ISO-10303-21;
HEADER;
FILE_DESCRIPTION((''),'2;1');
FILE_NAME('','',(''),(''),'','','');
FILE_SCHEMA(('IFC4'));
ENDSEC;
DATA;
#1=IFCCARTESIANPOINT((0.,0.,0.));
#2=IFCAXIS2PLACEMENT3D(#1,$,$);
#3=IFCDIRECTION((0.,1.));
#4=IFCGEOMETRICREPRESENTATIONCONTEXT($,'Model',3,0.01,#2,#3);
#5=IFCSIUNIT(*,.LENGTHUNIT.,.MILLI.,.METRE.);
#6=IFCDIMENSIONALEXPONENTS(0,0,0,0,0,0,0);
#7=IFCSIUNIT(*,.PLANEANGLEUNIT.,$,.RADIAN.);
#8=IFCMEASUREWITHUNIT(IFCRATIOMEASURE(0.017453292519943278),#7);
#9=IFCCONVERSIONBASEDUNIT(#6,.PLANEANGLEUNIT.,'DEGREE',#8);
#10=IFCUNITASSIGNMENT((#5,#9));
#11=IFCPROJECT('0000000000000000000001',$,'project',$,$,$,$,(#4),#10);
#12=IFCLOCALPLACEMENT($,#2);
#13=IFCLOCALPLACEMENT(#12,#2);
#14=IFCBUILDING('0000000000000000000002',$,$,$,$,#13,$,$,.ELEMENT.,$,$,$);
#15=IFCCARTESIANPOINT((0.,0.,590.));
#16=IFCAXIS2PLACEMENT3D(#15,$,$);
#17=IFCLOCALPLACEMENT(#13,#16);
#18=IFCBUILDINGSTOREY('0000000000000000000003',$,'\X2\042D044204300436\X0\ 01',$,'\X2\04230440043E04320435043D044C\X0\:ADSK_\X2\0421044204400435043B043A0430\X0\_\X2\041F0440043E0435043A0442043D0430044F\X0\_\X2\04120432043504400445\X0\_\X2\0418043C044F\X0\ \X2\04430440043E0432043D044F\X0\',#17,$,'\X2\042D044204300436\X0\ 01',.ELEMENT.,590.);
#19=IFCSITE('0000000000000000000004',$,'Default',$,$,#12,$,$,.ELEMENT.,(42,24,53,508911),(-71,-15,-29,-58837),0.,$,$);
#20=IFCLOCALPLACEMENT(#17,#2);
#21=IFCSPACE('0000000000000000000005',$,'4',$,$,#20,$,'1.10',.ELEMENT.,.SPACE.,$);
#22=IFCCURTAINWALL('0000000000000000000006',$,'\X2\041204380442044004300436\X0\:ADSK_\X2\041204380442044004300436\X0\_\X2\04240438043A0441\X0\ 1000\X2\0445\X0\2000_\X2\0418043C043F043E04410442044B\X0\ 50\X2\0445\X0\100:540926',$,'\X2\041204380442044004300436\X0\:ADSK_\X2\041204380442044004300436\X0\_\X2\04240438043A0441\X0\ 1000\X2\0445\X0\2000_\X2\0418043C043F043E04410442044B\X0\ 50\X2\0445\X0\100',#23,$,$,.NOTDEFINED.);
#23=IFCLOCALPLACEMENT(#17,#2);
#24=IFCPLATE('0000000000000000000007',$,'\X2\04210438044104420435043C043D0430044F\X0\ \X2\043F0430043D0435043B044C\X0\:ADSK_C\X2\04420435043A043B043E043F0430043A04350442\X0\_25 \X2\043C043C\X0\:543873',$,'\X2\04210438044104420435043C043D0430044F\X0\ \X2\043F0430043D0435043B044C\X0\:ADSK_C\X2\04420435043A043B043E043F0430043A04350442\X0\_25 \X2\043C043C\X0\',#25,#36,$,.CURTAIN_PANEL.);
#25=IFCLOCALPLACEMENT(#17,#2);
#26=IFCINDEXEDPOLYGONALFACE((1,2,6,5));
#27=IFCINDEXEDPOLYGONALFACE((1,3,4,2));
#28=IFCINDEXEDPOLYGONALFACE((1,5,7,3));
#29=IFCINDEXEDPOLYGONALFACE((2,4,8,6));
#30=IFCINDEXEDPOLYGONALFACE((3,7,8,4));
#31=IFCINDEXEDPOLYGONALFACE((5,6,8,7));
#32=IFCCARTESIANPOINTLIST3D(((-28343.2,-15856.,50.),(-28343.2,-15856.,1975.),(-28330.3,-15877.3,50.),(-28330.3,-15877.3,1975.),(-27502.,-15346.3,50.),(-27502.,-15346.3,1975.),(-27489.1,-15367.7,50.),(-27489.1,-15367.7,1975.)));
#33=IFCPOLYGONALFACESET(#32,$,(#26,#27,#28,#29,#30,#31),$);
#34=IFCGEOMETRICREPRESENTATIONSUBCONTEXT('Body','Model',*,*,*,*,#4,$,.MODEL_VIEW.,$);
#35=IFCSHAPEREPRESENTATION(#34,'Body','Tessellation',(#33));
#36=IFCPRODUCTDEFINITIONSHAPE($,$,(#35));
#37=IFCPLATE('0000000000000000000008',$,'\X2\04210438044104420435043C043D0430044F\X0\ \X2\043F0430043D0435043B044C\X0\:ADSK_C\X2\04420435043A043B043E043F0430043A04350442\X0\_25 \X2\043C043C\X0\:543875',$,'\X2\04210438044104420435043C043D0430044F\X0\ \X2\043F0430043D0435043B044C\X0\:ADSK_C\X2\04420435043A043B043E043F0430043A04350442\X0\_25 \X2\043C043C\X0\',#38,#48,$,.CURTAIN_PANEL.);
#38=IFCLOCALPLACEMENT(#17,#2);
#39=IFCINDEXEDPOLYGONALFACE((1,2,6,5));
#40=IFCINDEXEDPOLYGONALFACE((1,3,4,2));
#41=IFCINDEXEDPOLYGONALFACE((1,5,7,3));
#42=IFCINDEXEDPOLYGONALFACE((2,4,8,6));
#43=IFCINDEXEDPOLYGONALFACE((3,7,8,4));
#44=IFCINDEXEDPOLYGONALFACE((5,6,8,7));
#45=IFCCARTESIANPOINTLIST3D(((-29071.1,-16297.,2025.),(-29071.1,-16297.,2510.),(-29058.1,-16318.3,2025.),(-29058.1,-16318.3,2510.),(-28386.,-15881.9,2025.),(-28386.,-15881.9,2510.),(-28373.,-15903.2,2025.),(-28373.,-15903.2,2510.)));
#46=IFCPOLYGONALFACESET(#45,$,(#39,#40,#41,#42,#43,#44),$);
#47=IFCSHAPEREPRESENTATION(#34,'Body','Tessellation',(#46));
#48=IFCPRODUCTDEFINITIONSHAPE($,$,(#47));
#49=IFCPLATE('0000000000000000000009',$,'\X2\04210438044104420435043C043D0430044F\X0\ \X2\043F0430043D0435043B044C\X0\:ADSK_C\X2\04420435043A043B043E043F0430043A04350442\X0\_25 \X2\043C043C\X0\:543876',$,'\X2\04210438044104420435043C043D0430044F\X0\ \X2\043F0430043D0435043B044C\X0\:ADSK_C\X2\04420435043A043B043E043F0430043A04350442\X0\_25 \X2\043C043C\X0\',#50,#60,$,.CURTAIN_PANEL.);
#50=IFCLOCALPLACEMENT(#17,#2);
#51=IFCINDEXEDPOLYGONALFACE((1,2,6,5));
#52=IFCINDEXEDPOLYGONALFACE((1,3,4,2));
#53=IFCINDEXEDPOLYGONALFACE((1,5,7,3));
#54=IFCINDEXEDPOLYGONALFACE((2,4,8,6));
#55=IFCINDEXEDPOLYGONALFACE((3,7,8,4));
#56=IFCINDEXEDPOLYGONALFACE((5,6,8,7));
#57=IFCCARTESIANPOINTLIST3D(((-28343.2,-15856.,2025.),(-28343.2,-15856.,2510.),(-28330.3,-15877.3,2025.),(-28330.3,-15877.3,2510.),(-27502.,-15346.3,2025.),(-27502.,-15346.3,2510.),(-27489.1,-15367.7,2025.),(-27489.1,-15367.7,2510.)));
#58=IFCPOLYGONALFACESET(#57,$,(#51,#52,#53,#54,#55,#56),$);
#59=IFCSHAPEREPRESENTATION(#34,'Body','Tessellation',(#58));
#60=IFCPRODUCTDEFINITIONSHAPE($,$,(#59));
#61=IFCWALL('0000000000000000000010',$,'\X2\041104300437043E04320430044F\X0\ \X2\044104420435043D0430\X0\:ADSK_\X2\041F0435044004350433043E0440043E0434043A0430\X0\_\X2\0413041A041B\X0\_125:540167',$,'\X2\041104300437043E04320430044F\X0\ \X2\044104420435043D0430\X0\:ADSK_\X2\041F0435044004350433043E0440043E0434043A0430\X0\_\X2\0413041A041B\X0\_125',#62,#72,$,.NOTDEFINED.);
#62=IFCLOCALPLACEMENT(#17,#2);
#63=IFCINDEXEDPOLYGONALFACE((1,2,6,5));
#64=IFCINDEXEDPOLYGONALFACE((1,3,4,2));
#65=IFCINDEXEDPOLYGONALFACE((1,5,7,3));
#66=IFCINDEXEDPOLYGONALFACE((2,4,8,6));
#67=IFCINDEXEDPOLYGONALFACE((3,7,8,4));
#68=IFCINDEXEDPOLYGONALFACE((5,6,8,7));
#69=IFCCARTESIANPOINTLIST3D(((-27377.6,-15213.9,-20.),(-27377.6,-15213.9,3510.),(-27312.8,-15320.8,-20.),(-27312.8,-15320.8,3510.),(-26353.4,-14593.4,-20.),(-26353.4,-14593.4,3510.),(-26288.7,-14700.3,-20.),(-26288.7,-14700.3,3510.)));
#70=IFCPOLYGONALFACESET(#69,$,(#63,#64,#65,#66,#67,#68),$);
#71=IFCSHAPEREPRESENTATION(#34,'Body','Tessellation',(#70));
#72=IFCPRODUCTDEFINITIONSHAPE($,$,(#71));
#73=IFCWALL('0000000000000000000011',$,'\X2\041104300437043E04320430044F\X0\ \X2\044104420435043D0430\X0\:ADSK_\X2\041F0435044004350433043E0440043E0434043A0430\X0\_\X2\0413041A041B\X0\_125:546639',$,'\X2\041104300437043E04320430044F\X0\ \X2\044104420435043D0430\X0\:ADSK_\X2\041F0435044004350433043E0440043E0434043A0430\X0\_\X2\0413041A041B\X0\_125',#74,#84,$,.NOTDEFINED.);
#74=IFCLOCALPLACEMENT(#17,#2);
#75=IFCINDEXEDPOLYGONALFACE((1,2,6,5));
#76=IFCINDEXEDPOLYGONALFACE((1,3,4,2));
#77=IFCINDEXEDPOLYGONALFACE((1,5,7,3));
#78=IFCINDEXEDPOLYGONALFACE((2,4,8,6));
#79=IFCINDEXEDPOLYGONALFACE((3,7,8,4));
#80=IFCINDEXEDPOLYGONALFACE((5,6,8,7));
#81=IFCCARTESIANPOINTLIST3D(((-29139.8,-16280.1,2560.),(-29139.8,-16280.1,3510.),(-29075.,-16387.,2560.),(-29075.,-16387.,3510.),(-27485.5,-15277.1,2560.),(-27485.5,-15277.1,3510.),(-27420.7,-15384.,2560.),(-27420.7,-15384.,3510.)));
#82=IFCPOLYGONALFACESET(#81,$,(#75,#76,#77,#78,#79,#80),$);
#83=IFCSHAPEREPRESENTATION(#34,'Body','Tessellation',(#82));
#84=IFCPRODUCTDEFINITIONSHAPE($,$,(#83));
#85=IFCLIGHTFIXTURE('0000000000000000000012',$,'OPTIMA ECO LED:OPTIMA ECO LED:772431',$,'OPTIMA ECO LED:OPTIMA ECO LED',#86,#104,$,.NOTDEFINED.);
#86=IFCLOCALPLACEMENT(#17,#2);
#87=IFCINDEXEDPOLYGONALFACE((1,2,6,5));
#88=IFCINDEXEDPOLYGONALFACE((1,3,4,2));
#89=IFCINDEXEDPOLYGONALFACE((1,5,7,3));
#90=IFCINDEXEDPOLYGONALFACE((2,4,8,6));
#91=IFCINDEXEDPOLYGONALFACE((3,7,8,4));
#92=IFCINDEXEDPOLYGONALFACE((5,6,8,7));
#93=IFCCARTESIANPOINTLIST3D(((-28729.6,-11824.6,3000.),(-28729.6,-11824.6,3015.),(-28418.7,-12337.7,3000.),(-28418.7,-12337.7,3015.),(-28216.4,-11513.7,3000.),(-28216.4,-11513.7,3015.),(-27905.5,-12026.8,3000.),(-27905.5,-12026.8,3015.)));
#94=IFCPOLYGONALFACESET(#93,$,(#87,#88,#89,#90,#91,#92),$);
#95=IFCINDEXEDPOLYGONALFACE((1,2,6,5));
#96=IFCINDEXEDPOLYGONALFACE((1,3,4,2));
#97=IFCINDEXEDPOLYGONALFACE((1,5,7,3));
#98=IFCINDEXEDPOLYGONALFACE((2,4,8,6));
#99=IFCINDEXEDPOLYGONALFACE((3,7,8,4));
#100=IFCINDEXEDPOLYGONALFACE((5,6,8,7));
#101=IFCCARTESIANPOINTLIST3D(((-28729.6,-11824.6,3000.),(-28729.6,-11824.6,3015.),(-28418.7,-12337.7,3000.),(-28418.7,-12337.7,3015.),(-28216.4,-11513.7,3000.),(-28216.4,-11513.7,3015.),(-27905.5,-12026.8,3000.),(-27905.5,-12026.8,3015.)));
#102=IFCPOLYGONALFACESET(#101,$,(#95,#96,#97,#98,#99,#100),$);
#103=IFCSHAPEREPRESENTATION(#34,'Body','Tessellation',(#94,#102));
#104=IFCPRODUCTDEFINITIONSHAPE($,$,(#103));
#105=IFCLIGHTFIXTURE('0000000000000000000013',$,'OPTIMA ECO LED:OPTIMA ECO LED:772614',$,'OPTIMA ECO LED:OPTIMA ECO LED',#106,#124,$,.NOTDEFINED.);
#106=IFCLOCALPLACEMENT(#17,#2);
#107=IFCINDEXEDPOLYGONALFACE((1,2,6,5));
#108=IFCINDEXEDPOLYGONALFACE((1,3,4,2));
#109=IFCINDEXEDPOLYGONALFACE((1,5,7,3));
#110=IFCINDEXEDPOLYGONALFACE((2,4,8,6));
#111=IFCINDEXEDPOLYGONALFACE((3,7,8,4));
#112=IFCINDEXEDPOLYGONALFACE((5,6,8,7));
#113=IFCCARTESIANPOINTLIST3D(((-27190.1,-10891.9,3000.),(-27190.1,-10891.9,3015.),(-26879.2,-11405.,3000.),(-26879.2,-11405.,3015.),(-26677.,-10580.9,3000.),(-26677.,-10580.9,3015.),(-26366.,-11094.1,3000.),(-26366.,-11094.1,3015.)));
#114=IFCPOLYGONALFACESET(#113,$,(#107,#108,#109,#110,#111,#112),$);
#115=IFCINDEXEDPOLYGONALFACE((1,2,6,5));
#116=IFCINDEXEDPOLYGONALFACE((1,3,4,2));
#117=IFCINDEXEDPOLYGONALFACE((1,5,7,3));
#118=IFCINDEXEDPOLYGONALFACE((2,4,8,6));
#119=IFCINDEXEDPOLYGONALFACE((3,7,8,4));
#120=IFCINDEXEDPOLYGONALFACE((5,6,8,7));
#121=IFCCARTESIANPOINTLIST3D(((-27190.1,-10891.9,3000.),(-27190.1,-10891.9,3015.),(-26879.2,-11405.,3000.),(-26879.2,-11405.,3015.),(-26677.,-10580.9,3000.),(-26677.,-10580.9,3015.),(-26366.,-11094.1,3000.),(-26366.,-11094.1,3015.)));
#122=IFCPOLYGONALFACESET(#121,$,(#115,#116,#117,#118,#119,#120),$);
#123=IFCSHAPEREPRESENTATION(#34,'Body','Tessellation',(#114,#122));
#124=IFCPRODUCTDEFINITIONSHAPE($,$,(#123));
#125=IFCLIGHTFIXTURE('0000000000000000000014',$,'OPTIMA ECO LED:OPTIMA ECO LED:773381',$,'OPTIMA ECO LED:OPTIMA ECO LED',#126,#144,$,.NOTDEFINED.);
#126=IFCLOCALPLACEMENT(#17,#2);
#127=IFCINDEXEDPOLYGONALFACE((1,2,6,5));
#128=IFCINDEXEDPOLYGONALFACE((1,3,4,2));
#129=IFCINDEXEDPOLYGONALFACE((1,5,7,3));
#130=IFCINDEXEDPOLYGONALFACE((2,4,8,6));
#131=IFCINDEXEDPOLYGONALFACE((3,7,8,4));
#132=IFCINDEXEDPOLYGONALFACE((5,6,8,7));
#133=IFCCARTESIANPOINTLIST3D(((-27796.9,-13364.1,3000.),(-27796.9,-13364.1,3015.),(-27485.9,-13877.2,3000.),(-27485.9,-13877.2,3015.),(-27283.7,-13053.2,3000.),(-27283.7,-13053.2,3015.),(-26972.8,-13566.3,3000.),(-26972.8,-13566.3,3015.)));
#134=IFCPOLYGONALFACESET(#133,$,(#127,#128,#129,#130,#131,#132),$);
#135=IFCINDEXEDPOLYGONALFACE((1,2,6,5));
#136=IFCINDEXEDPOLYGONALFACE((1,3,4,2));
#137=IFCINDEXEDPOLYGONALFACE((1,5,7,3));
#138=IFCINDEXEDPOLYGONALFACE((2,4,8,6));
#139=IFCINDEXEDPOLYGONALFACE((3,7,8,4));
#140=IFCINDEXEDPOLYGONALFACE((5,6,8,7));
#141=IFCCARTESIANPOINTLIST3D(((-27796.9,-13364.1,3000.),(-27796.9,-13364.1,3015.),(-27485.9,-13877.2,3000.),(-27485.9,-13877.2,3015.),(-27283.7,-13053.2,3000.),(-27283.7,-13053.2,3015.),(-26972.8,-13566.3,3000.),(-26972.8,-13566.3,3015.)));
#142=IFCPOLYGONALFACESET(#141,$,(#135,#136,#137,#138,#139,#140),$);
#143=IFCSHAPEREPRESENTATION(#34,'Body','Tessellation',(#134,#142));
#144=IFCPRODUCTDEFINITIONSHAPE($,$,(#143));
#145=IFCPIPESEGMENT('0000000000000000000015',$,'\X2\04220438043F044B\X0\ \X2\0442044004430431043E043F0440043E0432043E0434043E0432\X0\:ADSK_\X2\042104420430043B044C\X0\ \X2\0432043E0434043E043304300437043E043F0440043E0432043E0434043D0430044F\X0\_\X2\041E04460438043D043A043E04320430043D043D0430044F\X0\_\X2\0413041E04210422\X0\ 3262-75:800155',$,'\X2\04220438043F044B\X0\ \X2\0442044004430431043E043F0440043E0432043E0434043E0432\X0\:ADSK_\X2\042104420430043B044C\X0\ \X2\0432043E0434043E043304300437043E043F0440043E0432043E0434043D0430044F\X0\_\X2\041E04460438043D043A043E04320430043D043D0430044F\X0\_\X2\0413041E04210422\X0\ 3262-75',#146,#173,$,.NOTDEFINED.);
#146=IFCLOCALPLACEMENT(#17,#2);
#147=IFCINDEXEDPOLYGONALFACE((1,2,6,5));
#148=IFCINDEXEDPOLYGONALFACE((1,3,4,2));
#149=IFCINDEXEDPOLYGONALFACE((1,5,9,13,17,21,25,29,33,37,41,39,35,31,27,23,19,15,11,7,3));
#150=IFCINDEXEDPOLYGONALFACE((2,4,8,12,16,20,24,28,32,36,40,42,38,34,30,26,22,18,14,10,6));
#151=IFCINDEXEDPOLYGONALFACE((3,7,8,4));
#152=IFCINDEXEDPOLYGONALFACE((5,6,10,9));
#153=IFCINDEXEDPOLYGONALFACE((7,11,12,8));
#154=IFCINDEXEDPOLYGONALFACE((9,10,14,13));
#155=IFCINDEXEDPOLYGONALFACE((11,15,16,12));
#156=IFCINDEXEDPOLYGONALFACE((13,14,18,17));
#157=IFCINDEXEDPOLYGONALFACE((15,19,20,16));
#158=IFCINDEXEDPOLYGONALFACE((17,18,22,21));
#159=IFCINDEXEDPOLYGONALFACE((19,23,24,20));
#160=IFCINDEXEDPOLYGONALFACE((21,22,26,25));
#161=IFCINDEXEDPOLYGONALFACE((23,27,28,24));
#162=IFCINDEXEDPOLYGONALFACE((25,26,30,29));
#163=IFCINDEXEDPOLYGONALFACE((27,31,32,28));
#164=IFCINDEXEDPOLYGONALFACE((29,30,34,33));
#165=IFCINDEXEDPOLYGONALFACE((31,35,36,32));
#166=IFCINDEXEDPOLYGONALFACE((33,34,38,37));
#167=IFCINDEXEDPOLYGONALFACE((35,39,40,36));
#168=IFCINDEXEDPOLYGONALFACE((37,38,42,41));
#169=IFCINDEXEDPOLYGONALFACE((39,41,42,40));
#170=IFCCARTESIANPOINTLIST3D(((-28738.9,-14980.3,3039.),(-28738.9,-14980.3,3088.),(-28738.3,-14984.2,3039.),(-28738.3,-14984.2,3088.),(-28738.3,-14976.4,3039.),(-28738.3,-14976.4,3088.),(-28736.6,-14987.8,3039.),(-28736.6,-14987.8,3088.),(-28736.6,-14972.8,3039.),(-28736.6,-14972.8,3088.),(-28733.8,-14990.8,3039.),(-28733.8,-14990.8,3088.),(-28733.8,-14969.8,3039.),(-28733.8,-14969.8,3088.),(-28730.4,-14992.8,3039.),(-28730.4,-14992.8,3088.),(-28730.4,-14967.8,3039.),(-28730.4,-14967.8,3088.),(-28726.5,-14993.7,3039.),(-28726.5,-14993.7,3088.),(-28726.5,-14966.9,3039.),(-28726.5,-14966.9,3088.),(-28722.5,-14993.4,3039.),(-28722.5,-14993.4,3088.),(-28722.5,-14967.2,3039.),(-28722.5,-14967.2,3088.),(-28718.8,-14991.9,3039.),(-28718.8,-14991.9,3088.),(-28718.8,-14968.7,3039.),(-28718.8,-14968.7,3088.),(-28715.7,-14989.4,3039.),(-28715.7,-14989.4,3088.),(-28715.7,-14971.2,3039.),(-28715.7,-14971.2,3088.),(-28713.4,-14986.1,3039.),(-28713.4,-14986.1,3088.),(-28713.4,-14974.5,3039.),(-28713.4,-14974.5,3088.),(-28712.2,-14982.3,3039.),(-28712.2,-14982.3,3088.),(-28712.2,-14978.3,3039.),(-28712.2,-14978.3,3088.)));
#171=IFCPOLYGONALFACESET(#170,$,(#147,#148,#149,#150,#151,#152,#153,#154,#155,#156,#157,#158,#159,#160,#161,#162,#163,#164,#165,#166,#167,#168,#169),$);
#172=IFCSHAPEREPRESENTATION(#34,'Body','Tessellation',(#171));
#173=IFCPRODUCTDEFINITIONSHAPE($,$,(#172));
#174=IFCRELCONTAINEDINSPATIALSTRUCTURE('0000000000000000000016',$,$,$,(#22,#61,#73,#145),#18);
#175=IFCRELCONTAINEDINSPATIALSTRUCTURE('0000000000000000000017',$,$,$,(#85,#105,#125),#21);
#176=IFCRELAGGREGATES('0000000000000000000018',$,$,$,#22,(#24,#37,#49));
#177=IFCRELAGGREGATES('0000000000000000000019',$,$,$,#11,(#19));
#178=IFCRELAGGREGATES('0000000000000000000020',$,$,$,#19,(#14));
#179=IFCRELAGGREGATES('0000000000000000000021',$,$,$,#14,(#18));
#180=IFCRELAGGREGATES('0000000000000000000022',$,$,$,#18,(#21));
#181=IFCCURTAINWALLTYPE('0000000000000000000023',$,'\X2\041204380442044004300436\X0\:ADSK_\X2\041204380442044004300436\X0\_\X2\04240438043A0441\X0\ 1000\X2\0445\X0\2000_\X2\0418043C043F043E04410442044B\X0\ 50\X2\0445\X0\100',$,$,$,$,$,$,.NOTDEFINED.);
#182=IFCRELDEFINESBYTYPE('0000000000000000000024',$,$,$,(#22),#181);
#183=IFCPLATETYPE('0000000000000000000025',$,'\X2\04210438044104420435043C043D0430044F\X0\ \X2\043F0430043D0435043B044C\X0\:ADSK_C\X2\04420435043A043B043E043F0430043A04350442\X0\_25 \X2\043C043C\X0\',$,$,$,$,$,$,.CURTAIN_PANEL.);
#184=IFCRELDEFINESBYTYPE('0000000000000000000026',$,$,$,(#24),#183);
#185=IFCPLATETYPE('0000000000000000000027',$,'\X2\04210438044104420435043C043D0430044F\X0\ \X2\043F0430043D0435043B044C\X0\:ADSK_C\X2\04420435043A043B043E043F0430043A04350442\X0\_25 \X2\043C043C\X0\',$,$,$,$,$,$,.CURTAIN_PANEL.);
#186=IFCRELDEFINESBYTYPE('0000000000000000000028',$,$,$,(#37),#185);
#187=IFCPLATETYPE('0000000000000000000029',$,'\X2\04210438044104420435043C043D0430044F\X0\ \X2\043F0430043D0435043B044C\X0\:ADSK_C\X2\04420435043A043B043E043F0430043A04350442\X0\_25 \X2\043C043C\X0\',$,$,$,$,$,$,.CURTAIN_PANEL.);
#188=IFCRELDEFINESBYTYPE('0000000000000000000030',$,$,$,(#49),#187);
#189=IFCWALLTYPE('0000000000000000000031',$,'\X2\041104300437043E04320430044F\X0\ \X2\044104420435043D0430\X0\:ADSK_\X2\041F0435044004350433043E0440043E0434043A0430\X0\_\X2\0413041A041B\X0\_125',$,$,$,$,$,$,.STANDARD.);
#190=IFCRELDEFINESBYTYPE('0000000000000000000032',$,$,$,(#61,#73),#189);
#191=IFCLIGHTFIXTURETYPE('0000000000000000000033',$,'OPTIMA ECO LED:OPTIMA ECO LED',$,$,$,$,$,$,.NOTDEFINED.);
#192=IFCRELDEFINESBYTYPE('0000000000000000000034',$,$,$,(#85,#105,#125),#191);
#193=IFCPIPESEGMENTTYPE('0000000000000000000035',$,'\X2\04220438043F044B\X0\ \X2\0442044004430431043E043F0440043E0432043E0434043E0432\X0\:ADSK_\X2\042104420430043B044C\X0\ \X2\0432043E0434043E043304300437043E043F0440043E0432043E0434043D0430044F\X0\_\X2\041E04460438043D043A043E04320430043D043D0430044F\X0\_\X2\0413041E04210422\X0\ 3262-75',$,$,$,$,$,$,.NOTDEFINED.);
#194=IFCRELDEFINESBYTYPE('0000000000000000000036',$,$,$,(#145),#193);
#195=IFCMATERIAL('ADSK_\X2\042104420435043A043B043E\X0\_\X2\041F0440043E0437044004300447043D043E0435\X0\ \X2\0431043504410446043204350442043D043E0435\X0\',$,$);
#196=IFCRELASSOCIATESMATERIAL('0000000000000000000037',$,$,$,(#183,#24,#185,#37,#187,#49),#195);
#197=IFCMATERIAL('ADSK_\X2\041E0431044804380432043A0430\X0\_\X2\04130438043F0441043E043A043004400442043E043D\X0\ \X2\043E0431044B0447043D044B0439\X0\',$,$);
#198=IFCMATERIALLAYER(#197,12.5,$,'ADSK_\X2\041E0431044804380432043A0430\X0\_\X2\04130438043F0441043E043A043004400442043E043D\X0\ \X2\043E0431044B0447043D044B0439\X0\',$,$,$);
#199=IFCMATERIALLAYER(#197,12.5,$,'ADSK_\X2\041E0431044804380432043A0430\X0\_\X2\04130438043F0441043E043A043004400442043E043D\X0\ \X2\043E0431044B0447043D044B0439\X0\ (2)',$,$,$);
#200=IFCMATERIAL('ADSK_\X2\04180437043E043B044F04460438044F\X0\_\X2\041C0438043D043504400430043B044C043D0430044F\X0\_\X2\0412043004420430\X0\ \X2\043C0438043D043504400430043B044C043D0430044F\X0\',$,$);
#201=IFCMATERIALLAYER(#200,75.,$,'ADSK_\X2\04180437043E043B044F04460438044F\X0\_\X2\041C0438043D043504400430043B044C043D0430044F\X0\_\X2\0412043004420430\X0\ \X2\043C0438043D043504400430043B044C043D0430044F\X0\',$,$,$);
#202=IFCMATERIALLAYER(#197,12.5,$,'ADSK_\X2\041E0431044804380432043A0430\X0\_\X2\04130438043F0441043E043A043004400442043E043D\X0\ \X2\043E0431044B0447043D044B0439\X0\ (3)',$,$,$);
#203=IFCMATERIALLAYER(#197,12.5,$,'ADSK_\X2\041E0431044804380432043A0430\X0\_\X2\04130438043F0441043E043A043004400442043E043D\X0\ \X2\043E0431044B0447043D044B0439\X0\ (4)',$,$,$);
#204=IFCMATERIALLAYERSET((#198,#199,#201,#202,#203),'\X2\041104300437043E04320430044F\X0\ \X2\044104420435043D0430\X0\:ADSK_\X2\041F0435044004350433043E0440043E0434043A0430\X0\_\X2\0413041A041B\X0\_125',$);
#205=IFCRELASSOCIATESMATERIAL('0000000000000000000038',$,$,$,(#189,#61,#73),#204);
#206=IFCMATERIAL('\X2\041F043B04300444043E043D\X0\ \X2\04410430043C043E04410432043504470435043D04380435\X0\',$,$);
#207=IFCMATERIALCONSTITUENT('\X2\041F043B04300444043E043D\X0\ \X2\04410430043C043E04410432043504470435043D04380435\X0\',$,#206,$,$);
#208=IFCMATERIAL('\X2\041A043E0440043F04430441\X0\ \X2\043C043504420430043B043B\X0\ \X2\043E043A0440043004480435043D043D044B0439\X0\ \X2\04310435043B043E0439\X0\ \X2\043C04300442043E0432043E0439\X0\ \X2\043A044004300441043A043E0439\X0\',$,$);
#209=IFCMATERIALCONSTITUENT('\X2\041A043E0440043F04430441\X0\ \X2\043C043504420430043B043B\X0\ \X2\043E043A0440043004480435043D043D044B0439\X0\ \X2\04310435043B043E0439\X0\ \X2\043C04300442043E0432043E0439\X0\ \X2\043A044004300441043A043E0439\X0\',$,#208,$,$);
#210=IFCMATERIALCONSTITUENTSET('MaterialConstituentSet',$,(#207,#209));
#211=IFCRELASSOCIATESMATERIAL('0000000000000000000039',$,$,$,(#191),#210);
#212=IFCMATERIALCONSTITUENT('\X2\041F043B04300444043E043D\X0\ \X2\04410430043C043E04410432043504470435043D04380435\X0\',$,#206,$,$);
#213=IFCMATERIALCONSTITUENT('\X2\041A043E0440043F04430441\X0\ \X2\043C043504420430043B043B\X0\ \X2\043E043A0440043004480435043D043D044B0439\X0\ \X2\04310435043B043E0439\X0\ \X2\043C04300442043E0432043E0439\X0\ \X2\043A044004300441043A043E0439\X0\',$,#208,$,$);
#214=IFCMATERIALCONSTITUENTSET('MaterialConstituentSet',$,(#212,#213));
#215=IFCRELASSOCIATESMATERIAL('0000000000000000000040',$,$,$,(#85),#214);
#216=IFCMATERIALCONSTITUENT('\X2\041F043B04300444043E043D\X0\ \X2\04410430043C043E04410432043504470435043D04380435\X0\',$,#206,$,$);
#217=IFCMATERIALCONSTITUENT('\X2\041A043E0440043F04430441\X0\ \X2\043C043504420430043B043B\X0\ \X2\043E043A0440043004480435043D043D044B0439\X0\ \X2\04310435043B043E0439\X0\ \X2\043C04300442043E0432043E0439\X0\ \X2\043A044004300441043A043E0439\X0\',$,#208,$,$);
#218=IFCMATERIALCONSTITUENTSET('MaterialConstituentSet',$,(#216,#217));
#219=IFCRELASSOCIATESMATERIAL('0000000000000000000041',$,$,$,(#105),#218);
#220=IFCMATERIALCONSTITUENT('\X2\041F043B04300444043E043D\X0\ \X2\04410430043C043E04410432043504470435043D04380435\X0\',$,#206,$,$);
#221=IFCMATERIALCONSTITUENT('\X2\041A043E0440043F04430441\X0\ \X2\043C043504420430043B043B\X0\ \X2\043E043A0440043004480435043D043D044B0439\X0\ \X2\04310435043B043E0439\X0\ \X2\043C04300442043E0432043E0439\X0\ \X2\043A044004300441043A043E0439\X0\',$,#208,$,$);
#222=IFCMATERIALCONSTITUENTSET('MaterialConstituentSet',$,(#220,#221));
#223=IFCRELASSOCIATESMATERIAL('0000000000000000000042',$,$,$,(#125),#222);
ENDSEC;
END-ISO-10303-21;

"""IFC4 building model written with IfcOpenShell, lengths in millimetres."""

from ifc_helpers import new_model, entity, si_unit, converted_unit, direction, frame, frame_2d, origin, origin_2d_with_axis, place, context, subcontext, project, spatial, polyline, rectangle, circle, outline, extrude, source, transform, mapped, material, layer, layer_set, layer_usage, constituent, constituent_set, type_object, type_shapes, element, aggregate, save


model = new_model("IFC4")

# Units and contexts
model_context = context("Model", 3, precision=0.01, world=origin(), true_north=direction((0.0, 1.0)))
body_context = subcontext(model_context, "Body", "Model", "MODEL_VIEW")
ifc_project = project(units=[si_unit("LENGTHUNIT", "METRE", prefix="MILLI"), converted_unit("PLANEANGLEUNIT", "DEGREE", entity("IfcRatioMeasure", 0.017453292519943278), si_unit("PLANEANGLEUNIT", "RADIAN"), dimensions=[0, 0, 0, 0, 0, 0, 0])], contexts=[model_context])

# Site, building, storey
site_placement = place(None, origin())
site = spatial("IfcSite", under=ifc_project, at=site_placement, Name="Default", CompositionType="ELEMENT", RefLatitude=(42, 24, 53, 508911), RefLongitude=(-71, -15, -29, -58837), RefElevation=0.0)
building_placement = place(site_placement, origin())
building = spatial("IfcBuilding", under=site, at=building_placement, CompositionType="ELEMENT")
storey_placement = place(building_placement, frame((0.0, 0.0, 590.0)))
storey = spatial("IfcBuildingStorey", under=building, at=storey_placement, Name="Этаж 01", ObjectType="Уровень:ADSK_Стрелка_Проектная_Вверх_Имя уровня", LongName="Этаж 01", CompositionType="ELEMENT", Elevation=590.0)

# Curtain wall
curtain_wall_type = type_object("IfcCurtainWallType", Name="Витраж:ADSK_Витраж_Фикс 1000х2000_Импосты 50х100", PredefinedType="NOTDEFINED")
curtain_wall_placement = place(storey_placement, frame((0.0, 0.0, -590.0)))
curtain_wall = element("IfcCurtainWall", 1, at=curtain_wall_placement, inside=storey, type_object=curtain_wall_type, Name="Витраж:ADSK_Витраж_Фикс 1000х2000_Импосты 50х100:540926", ObjectType="Витраж:ADSK_Витраж_Фикс 1000х2000_Импосты 50х100", PredefinedType="NOTDEFINED")

# Plates
ifc_material_1 = material(Name="ADSK_Стекло_Прозрачное бесцветное")
plate_type_1 = type_object("IfcPlateType", Name="Системная панель:ADSK_Cтеклопакет_25 мм", PredefinedType="CURTAIN_PANEL", material=ifc_material_1)
shared_shape_1 = source(origin(), body_context, "Body", "SweptSolid", [
    extrude(rectangle(XDim=25.0, YDim=983.5, at=frame_2d((0.0, 0.0), x_axis=(1.0, 0.0))), frame((0.0, 0.0, 0.0), z_axis=(0.0, 0.0, 1.0), x_axis=(0.0, 1.0, 0.0)), (0.0, 0.0, 1.0), 1925.0),
])
type_shapes(plate_type_1, [shared_shape_1])
plate_1_placement = place(curtain_wall_placement, frame((-27916.1, -15611.8, 640.0), z_axis=(0.0, 0.0, 1.0), x_axis=(0.855267, 0.518188, 0.0)))
plate_1 = element("IfcPlate", 2, at=plate_1_placement, type_object=plate_type_1, material=ifc_material_1, Name="Системная панель:ADSK_Cтеклопакет_25 мм:543873", ObjectType="Системная панель:ADSK_Cтеклопакет_25 мм", PredefinedType="CURTAIN_PANEL", context=body_context, shape_type="MappedRepresentation", body=[
    mapped(shared_shape_1, transform((0.0, 0.0, 0.0), scale=1.0)),
])
plate_type_2 = type_object("IfcPlateType", Name="Системная панель:ADSK_Cтеклопакет_25 мм", PredefinedType="CURTAIN_PANEL", material=ifc_material_1)
shared_shape_2 = source(origin(), body_context, "Body", "SweptSolid", [
    extrude(rectangle(XDim=25.0, YDim=801.0, at=frame_2d((0.0, 0.0), x_axis=(1.0, 0.0))), frame((0.0, 0.0, 0.0), z_axis=(0.0, 0.0, 1.0), x_axis=(0.0, 1.0, 0.0)), (0.0, 0.0, 1.0), 485.0),
])
type_shapes(plate_type_2, [shared_shape_2])
plate_2_placement = place(curtain_wall_placement, frame((-28722.0, -16100.1, 2615.0), z_axis=(0.0, 0.0, 1.0), x_axis=(0.855267, 0.518188, 0.0)))
plate_2 = element("IfcPlate", 3, at=plate_2_placement, type_object=plate_type_2, material=ifc_material_1, Name="Системная панель:ADSK_Cтеклопакет_25 мм:543875", ObjectType="Системная панель:ADSK_Cтеклопакет_25 мм", PredefinedType="CURTAIN_PANEL", context=body_context, shape_type="MappedRepresentation", body=[
    mapped(shared_shape_2, transform((0.0, 0.0, 0.0), scale=1.0)),
])
plate_type_3 = type_object("IfcPlateType", Name="Системная панель:ADSK_Cтеклопакет_25 мм", PredefinedType="CURTAIN_PANEL", material=ifc_material_1)
shared_shape_3 = source(origin(), body_context, "Body", "SweptSolid", [
    extrude(rectangle(XDim=25.0, YDim=983.5, at=frame_2d((0.0, 0.0), x_axis=(1.0, 0.0))), frame((0.0, 0.0, 0.0), z_axis=(0.0, 0.0, 1.0), x_axis=(0.0, 1.0, 0.0)), (0.0, 0.0, 1.0), 485.0),
])
type_shapes(plate_type_3, [shared_shape_3])
plate_3_placement = place(curtain_wall_placement, frame((-27916.1, -15611.8, 2615.0), z_axis=(0.0, 0.0, 1.0), x_axis=(0.855267, 0.518188, 0.0)))
plate_3 = element("IfcPlate", 4, at=plate_3_placement, type_object=plate_type_3, material=ifc_material_1, Name="Системная панель:ADSK_Cтеклопакет_25 мм:543876", ObjectType="Системная панель:ADSK_Cтеклопакет_25 мм", PredefinedType="CURTAIN_PANEL", context=body_context, shape_type="MappedRepresentation", body=[
    mapped(shared_shape_3, transform((0.0, 0.0, 0.0), scale=1.0)),
])
aggregate(curtain_wall, [plate_1, plate_2, plate_3])

# Walls
ifc_material_2 = material(Name="ADSK_Обшивка_Гипсокартон обычный")
ifc_layer_1 = layer(ifc_material_2, 12.5, Name="ADSK_Обшивка_Гипсокартон обычный")
ifc_layer_2 = layer(ifc_material_2, 12.5, Name="ADSK_Обшивка_Гипсокартон обычный (2)")
ifc_material_3 = material(Name="ADSK_Изоляция_Минеральная_Вата минеральная")
ifc_layer_3 = layer(ifc_material_3, 75.0, Name="ADSK_Изоляция_Минеральная_Вата минеральная")
ifc_layer_4 = layer(ifc_material_2, 12.5, Name="ADSK_Обшивка_Гипсокартон обычный (3)")
ifc_layer_5 = layer(ifc_material_2, 12.5, Name="ADSK_Обшивка_Гипсокартон обычный (4)")
ifc_layer_set = layer_set([ifc_layer_1, ifc_layer_2, ifc_layer_3, ifc_layer_4, ifc_layer_5], Name="Базовая стена:ADSK_Перегородка_ГКЛ_125")
ifc_layer_usage_1 = layer_usage(ifc_layer_set, "AXIS2", "NEGATIVE", 62.5)
wall_type = type_object("IfcWallType", Name="Базовая стена:ADSK_Перегородка_ГКЛ_125", PredefinedType="STANDARD", material=ifc_layer_set)
wall_1_placement = place(storey_placement, frame((-27345.2, -15267.4, -20.0), z_axis=(0.0, 0.0, 1.0), x_axis=(0.855267, 0.518188, 0.0)))
element("IfcWall", 5, at=wall_1_placement, inside=storey, type_object=wall_type, material=ifc_layer_usage_1, Name="Базовая стена:ADSK_Перегородка_ГКЛ_125:540167", ObjectType="Базовая стена:ADSK_Перегородка_ГКЛ_125", PredefinedType="NOTDEFINED", context=body_context, shape_type="SweptSolid", body=[
    extrude(rectangle(XDim=1197.5, YDim=125.0, at=frame_2d((598.7, 0.0), x_axis=(-1.0, 0.0))), origin(), (0.0, 0.0, 1.0), 3530.0),
])
ifc_layer_usage_2 = layer_usage(ifc_layer_set, "AXIS2", "NEGATIVE", 62.5)
wall_2_placement = place(storey_placement, frame((-29107.4, -16333.6, 2560.0), z_axis=(0.0, 0.0, 1.0), x_axis=(0.855102, 0.51846, 0.0)))
element("IfcWall", 6, at=wall_2_placement, inside=storey, type_object=wall_type, material=ifc_layer_usage_2, Name="Базовая стена:ADSK_Перегородка_ГКЛ_125:546639", ObjectType="Базовая стена:ADSK_Перегородка_ГКЛ_125", PredefinedType="NOTDEFINED", context=body_context, shape_type="SweptSolid", body=[
    extrude(outline(polyline([(1934.6, -62.5), (1934.6, 62.5), (0.0, 62.5), (0.0, -62.5), (1934.6, -62.5)])), origin(), (0.0, 0.0, 1.0), 950.0),
])

# Shared definitions
space_1_placement = place(storey_placement, origin())
space_1 = spatial("IfcSpace", under=storey, at=space_1_placement, Name="4", LongName="1.10", CompositionType="ELEMENT", PredefinedType="SPACE")

# Light fixtures
ifc_material_4 = material(Name="Плафон самосвечение")
ifc_constituent_1 = constituent(ifc_material_4, Name="Плафон самосвечение")
ifc_material_5 = material(Name="Корпус металл окрашенный белой матовой краской")
ifc_constituent_2 = constituent(ifc_material_5, Name="Корпус металл окрашенный белой матовой краской")
ifc_constituent_set_1 = constituent_set(constituents=[ifc_constituent_1, ifc_constituent_2], Name="MaterialConstituentSet")
ifc_constituent_3 = constituent(ifc_material_4, Name="Плафон самосвечение")
ifc_constituent_4 = constituent(ifc_material_5, Name="Корпус металл окрашенный белой матовой краской")
ifc_constituent_set_2 = constituent_set(constituents=[ifc_constituent_3, ifc_constituent_4], Name="MaterialConstituentSet")
light_fixture_type = type_object("IfcLightFixtureType", Name="OPTIMA ECO LED:OPTIMA ECO LED", PredefinedType="NOTDEFINED", material=ifc_constituent_set_2)
shared_shape_4 = source(origin(), body_context, "Body", "SweptSolid", [
    extrude(rectangle(XDim=600.0, YDim=600.0, at=frame_2d((0.0, 0.0), x_axis=(1.0, 0.0))), frame((0.0, 0.0, -15.0)), (0.0, 0.0, 1.0), 15.0),
    extrude(rectangle(XDim=600.0, YDim=600.0, at=frame_2d((0.0, 0.0), x_axis=(1.0, 0.0))), frame((0.0, 0.0, -15.0)), (0.0, 0.0, 1.0), 15.0),
])
type_shapes(light_fixture_type, [shared_shape_4])
light_fixture_1_placement = place(space_1_placement, frame((-28317.6, -11925.7, 3000.0), z_axis=(0.0, 0.0, -1.0), x_axis=(0.855267, 0.518188, 0.0)))
element("IfcLightFixture", 7, at=light_fixture_1_placement, inside=space_1, type_object=light_fixture_type, material=ifc_constituent_set_1, Name="OPTIMA ECO LED:OPTIMA ECO LED:772431", ObjectType="OPTIMA ECO LED:OPTIMA ECO LED", PredefinedType="NOTDEFINED", context=body_context, shape_type="MappedRepresentation", body=[
    mapped(shared_shape_4, transform((0.0, 0.0, 0.0), scale=1.0)),
])
ifc_constituent_5 = constituent(ifc_material_4, Name="Плафон самосвечение")
ifc_constituent_6 = constituent(ifc_material_5, Name="Корпус металл окрашенный белой матовой краской")
ifc_constituent_set_3 = constituent_set(constituents=[ifc_constituent_5, ifc_constituent_6], Name="MaterialConstituentSet")
light_fixture_2_placement = place(space_1_placement, frame((-26778.1, -10993.0, 3000.0), z_axis=(0.0, 0.0, -1.0), x_axis=(0.855267, 0.518188, 0.0)))
element("IfcLightFixture", 8, at=light_fixture_2_placement, inside=space_1, type_object=light_fixture_type, material=ifc_constituent_set_3, Name="OPTIMA ECO LED:OPTIMA ECO LED:772614", ObjectType="OPTIMA ECO LED:OPTIMA ECO LED", PredefinedType="NOTDEFINED", context=body_context, shape_type="MappedRepresentation", body=[
    mapped(shared_shape_4, transform((0.0, 0.0, 0.0), scale=1.0)),
])
ifc_constituent_7 = constituent(ifc_material_4, Name="Плафон самосвечение")
ifc_constituent_8 = constituent(ifc_material_5, Name="Корпус металл окрашенный белой матовой краской")
ifc_constituent_set_4 = constituent_set(constituents=[ifc_constituent_7, ifc_constituent_8], Name="MaterialConstituentSet")
light_fixture_3_placement = place(space_1_placement, frame((-27384.8, -13465.2, 3000.0), z_axis=(0.0, 0.0, -1.0), x_axis=(0.855267, 0.518188, 0.0)))
element("IfcLightFixture", 9, at=light_fixture_3_placement, inside=space_1, type_object=light_fixture_type, material=ifc_constituent_set_4, Name="OPTIMA ECO LED:OPTIMA ECO LED:773381", ObjectType="OPTIMA ECO LED:OPTIMA ECO LED", PredefinedType="NOTDEFINED", context=body_context, shape_type="MappedRepresentation", body=[
    mapped(shared_shape_4, transform((0.0, 0.0, 0.0), scale=1.0)),
])

# Pipe segment
pipe_segment_type = type_object("IfcPipeSegmentType", Name="Типы трубопроводов:ADSK_Сталь водогазопроводная_Оцинкованная_ГОСТ 3262-75", PredefinedType="NOTDEFINED")
pipe_segment_1_placement = place(storey_placement, frame((-28740.5, -14995.3, 3088.0)))
element("IfcPipeSegment", 10, at=pipe_segment_1_placement, inside=storey, type_object=pipe_segment_type, Name="Типы трубопроводов:ADSK_Сталь водогазопроводная_Оцинкованная_ГОСТ 3262-75:800155", ObjectType="Типы трубопроводов:ADSK_Сталь водогазопроводная_Оцинкованная_ГОСТ 3262-75", PredefinedType="NOTDEFINED", context=body_context, shape_type="SweptSolid", body=[
    extrude(circle(Radius=13.4, at=origin_2d_with_axis()), frame((15.0, 15.0, -49.0), z_axis=(0.0, 0.0, 1.0), x_axis=(-1.0, 0.0, 0.0)), (0.0, 0.0, 1.0), 49.0),
])

save(model, "model.ifc")
